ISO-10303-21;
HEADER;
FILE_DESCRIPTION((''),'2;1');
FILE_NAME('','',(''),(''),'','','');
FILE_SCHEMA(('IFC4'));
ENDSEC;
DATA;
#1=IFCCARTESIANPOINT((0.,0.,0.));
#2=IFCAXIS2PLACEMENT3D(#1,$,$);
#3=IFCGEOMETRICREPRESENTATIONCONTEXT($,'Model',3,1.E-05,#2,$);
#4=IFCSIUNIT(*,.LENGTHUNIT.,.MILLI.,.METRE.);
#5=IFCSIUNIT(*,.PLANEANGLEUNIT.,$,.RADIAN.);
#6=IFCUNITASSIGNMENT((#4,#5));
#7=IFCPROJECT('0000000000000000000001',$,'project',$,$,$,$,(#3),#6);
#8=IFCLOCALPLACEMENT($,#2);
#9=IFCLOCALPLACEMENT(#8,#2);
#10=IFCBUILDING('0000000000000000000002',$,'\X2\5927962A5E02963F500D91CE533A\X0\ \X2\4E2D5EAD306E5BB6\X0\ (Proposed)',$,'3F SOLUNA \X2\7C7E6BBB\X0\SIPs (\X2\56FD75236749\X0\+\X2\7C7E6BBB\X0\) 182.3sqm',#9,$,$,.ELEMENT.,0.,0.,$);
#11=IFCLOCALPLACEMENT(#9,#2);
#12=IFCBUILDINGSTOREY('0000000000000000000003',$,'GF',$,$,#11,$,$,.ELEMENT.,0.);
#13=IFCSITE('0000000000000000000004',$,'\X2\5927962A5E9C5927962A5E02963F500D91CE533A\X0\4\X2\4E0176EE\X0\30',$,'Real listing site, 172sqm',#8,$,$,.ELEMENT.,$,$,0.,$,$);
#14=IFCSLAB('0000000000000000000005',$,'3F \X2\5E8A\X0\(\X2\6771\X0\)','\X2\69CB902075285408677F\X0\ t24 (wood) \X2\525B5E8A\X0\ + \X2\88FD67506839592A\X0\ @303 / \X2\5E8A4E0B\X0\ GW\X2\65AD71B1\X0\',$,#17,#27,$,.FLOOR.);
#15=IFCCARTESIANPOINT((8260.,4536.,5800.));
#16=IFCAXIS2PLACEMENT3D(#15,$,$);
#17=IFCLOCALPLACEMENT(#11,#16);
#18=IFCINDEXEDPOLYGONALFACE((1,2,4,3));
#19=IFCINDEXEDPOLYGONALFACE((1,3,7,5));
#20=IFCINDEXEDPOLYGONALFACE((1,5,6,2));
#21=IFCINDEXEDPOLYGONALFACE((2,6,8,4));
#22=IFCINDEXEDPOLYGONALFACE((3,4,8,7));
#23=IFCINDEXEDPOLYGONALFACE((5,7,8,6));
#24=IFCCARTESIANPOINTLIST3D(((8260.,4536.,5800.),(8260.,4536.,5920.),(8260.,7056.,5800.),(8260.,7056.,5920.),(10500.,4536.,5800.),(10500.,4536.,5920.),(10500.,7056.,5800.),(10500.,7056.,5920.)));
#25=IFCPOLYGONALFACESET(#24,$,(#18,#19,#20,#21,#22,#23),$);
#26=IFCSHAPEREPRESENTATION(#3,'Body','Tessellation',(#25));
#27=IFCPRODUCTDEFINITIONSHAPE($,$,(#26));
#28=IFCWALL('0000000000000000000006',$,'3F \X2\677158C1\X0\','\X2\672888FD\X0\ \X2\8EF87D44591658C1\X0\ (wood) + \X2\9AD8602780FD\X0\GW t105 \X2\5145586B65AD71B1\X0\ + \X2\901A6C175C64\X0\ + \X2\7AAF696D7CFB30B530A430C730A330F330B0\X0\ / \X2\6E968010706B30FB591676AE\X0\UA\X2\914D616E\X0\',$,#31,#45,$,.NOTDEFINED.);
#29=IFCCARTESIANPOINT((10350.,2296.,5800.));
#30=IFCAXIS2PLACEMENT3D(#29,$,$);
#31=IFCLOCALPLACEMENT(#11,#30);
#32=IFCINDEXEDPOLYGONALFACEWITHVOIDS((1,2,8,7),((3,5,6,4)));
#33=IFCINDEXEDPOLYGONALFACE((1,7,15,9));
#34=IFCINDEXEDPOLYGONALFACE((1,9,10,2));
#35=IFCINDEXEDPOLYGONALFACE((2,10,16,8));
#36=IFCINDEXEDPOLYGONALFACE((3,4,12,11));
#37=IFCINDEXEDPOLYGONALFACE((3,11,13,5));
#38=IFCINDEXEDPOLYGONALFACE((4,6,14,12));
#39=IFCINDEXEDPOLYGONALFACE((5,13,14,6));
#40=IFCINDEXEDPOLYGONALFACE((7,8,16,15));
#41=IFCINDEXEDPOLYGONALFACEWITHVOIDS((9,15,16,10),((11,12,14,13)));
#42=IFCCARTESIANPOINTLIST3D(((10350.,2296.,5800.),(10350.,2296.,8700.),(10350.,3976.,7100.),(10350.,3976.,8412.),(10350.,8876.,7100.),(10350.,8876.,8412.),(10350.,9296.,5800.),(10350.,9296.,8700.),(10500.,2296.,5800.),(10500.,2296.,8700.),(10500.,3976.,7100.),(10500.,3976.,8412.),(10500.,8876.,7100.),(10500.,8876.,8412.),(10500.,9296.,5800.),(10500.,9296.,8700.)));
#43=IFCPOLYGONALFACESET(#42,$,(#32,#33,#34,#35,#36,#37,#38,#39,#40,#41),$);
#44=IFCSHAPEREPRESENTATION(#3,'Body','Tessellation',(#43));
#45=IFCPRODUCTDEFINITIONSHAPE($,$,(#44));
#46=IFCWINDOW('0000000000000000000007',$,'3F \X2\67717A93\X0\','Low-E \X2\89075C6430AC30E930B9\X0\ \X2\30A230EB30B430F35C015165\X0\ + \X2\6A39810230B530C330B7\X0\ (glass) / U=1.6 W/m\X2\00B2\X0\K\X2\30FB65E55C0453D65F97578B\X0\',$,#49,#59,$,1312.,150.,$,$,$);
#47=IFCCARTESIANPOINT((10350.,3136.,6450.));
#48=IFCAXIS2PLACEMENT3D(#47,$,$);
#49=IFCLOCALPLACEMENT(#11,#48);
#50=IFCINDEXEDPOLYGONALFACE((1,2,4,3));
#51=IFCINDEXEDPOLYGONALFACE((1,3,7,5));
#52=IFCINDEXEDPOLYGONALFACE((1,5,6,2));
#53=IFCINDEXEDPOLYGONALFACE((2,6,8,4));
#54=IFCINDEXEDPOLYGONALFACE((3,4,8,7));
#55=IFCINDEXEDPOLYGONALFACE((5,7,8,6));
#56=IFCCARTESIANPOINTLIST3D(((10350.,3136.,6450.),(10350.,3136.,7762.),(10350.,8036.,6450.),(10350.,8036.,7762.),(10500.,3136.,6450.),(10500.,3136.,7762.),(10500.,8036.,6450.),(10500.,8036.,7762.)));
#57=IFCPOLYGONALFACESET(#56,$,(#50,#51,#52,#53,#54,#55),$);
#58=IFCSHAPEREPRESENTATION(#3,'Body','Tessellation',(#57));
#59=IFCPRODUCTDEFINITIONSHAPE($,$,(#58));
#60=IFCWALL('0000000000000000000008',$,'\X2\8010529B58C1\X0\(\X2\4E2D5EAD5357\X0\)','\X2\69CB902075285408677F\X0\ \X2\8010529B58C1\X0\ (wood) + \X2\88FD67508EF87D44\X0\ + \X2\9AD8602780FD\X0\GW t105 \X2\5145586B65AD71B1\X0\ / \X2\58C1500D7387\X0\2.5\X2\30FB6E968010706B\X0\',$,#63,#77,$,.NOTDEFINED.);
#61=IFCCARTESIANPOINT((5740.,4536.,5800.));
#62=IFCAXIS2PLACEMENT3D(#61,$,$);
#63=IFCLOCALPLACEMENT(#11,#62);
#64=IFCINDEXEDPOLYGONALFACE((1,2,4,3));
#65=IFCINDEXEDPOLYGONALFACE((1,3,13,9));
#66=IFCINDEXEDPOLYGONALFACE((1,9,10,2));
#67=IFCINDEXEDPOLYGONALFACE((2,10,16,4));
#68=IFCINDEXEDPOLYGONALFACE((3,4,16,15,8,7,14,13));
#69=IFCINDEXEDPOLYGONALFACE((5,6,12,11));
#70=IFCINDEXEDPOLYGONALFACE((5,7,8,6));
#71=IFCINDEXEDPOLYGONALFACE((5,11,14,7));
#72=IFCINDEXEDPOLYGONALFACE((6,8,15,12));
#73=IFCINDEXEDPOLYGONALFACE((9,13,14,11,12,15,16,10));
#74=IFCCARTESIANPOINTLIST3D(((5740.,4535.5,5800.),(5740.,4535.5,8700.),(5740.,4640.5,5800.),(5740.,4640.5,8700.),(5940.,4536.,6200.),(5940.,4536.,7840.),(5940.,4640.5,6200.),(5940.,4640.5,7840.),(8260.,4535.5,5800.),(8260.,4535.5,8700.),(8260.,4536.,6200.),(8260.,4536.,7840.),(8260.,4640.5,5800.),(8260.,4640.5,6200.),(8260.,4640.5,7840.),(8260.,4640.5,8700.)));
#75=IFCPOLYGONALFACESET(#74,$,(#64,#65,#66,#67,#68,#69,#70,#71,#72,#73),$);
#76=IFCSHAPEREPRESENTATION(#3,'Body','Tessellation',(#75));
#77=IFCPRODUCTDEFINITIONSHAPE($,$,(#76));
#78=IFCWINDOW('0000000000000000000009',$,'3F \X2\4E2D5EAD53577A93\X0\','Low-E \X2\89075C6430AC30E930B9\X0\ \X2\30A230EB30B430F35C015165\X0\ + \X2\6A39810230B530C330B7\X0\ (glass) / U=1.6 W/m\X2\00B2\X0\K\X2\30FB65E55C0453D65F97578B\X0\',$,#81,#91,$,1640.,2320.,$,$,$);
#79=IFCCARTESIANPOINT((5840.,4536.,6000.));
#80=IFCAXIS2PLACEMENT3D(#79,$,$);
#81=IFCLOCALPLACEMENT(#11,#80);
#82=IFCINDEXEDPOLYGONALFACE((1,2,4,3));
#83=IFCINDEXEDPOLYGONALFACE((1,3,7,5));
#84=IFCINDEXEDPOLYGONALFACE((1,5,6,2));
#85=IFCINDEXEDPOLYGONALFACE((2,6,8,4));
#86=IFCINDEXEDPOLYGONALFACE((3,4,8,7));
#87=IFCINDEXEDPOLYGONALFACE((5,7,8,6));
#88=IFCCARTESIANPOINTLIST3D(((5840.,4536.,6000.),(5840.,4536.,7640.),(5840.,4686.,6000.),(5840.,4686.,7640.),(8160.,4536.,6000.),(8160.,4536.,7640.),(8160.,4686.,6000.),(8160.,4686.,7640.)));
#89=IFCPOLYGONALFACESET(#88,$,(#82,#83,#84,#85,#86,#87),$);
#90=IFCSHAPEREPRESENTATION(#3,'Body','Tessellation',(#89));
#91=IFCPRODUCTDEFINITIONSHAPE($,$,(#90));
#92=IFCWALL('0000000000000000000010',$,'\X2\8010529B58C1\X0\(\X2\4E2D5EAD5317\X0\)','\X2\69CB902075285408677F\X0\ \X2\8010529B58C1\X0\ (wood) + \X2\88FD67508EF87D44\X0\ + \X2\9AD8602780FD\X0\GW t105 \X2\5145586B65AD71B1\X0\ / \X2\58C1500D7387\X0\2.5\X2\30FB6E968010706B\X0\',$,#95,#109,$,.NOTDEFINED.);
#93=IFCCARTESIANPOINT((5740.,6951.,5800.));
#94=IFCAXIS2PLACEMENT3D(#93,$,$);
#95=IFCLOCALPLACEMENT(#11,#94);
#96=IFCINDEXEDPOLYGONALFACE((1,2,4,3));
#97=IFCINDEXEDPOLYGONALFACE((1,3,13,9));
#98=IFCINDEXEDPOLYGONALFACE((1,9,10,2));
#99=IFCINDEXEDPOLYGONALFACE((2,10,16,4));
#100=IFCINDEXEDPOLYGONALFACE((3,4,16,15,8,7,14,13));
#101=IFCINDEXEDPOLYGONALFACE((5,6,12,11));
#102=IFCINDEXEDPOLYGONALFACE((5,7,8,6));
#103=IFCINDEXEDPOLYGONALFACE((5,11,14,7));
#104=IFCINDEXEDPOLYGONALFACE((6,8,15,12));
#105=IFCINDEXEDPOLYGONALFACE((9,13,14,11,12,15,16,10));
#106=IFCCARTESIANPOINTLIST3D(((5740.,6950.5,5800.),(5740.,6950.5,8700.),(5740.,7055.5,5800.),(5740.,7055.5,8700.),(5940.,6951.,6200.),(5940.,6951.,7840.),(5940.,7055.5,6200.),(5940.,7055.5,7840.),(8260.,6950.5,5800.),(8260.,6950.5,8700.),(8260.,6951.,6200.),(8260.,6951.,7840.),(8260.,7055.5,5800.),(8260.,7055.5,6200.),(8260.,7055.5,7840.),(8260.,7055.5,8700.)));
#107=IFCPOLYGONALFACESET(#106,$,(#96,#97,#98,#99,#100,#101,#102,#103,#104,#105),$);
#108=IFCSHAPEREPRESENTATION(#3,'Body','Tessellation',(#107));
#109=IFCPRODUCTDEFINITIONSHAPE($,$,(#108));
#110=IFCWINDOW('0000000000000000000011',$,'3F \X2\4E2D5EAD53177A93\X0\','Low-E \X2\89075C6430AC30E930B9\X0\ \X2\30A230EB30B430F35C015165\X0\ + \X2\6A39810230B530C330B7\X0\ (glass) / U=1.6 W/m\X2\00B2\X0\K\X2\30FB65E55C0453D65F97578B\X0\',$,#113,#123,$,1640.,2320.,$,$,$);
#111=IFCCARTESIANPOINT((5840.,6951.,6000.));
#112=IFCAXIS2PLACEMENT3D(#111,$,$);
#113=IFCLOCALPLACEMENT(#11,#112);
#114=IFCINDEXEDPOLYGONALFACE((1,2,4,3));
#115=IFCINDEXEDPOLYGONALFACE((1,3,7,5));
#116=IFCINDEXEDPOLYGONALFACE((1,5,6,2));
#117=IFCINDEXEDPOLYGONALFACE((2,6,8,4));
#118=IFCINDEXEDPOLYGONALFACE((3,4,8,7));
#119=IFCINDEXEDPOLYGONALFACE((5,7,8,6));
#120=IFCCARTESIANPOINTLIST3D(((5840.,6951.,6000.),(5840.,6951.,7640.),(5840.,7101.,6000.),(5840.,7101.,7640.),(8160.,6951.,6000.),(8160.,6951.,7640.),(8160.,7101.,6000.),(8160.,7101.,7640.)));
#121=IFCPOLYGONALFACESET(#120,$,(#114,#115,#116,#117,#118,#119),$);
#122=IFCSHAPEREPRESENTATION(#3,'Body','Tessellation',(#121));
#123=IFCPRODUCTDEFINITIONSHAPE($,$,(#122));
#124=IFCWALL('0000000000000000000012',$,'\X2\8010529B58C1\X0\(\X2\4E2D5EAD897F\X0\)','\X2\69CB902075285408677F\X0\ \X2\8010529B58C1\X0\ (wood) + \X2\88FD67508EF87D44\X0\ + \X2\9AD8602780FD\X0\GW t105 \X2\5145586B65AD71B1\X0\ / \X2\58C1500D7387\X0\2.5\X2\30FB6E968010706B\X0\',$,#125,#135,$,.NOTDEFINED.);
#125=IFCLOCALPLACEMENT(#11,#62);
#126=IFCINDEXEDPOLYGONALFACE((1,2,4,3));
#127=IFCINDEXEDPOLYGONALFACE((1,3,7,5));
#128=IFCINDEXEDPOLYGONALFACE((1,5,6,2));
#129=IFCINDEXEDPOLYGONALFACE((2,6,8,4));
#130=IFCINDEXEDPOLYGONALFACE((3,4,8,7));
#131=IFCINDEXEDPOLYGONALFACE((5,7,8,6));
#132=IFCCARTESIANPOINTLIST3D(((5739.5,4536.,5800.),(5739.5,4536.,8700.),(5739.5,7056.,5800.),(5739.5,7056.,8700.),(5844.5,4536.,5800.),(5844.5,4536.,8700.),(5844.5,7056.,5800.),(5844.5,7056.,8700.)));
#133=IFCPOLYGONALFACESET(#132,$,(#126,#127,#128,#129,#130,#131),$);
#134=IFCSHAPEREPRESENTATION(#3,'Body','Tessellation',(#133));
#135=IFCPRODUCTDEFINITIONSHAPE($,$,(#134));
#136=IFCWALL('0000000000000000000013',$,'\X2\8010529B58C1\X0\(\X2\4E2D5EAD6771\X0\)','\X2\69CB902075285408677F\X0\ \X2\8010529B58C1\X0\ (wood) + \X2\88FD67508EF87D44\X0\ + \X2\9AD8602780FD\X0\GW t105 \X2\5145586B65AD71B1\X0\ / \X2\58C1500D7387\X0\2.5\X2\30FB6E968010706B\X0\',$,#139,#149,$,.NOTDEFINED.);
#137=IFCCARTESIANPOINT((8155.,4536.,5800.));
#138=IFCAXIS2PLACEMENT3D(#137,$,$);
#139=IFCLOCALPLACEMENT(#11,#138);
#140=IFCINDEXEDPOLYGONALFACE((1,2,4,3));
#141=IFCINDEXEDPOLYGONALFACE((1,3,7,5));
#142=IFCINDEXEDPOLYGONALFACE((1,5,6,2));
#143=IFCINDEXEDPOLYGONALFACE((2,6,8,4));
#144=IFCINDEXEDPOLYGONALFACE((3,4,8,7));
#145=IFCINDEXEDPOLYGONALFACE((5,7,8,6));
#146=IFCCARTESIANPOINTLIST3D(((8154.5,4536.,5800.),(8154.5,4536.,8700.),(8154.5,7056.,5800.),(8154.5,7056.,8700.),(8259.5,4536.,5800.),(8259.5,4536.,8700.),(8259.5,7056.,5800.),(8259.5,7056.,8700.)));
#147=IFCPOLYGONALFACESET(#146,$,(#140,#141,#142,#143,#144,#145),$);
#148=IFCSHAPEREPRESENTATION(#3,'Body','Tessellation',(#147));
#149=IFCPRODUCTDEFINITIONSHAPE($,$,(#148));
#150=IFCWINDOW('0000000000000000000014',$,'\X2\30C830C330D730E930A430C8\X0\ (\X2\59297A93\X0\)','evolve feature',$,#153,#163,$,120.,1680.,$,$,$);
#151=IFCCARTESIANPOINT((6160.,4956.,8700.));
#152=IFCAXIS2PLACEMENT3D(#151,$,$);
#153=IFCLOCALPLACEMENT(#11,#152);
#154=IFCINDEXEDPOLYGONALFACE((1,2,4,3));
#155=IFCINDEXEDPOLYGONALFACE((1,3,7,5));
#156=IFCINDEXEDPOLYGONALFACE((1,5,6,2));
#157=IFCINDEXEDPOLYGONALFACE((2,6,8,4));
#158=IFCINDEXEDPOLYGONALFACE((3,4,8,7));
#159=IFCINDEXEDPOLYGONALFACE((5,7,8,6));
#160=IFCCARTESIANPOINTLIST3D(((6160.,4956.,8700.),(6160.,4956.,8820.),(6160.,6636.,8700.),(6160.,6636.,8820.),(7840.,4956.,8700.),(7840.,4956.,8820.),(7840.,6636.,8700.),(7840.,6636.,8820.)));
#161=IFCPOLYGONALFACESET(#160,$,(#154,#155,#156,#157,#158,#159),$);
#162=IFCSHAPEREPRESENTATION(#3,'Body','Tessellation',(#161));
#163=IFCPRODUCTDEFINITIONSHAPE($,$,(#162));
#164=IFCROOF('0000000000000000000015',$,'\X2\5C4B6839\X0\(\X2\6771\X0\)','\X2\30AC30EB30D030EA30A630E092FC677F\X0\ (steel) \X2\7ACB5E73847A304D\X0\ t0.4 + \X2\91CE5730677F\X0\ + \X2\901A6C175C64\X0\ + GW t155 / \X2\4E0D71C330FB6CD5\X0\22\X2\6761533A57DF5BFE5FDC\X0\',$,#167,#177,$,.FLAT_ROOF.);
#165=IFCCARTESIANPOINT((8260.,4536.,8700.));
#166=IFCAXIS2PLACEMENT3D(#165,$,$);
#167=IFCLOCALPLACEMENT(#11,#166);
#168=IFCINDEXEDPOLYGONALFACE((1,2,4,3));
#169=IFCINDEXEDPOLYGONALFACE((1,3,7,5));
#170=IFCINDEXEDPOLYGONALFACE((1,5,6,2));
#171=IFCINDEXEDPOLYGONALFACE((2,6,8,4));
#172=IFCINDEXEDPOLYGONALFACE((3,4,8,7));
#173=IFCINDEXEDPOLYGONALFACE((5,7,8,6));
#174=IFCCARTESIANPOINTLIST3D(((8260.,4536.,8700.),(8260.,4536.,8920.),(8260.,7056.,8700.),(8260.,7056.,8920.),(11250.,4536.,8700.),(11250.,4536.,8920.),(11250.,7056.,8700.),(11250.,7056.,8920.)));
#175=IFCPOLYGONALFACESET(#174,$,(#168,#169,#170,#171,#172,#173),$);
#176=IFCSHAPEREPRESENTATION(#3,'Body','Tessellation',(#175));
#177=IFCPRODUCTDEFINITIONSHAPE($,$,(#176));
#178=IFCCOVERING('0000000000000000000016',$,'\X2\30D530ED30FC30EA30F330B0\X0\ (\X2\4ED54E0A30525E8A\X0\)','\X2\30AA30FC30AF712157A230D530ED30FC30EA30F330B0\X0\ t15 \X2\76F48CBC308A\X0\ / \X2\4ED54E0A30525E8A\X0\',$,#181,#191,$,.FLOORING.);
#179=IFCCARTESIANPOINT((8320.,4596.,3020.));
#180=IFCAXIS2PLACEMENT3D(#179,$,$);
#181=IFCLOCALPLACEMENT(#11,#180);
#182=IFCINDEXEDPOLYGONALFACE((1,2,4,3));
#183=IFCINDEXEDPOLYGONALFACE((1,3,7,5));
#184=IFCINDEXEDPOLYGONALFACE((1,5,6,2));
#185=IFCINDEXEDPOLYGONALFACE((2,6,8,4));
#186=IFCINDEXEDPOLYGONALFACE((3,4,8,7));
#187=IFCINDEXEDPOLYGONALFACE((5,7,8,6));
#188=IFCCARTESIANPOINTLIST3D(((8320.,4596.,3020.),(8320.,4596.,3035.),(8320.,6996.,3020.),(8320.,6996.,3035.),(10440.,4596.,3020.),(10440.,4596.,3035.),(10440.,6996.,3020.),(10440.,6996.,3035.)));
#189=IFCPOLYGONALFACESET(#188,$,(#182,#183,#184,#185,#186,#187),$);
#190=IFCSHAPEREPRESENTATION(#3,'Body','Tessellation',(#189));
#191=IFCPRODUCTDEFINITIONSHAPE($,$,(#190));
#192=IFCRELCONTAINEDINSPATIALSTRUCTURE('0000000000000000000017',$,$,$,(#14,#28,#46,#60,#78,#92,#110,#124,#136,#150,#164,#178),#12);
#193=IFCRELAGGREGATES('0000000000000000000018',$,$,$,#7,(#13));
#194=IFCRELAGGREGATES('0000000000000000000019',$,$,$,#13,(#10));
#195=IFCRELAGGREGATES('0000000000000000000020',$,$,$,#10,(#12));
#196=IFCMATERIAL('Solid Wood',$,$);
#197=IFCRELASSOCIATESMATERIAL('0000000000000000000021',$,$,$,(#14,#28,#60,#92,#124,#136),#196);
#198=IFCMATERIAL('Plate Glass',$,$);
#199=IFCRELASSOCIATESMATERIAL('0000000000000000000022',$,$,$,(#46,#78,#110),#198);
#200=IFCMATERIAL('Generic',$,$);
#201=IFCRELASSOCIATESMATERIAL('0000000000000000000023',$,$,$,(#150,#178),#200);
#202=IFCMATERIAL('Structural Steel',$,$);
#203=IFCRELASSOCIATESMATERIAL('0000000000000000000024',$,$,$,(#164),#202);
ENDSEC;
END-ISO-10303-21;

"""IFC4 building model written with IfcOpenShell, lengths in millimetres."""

from ifc_helpers import new_model, si_unit, frame, frame_2d, origin, place, context, project, spatial, rectangle, extrude, material, element, fill, save


model = new_model("IFC4")

# Units and contexts
model_context = context("Model", 3, precision=1e-05, world=origin())
ifc_project = project(units=[si_unit("LENGTHUNIT", "METRE", prefix="MILLI"), si_unit("PLANEANGLEUNIT", "RADIAN")], contexts=[model_context])

# Site, building, storey
site_placement = place(None, origin())
site = spatial("IfcSite", under=ifc_project, at=site_placement, Name="大阪府大阪市阿倍野区4丁目30", ObjectType="Real listing site, 172sqm", CompositionType="ELEMENT", RefElevation=0.0)
building_placement = place(site_placement, origin())
building = spatial("IfcBuilding", under=site, at=building_placement, Name="大阪市阿倍野区 中庭の家 (Proposed)", ObjectType="3F SOLUNA 籾殻SIPs (国産杉+籾殻) 182.3sqm", CompositionType="ELEMENT", ElevationOfRefHeight=0.0, ElevationOfTerrain=0.0)
storey_placement = place(building_placement, origin())
storey = spatial("IfcBuildingStorey", under=building, at=storey_placement, Name="GF", CompositionType="ELEMENT", Elevation=0.0)

# Slab
ifc_material_1 = material(Name="Solid Wood")
slab_placement = place(storey_placement, frame((8260.0, 4536.0, 5800.0)))
element("IfcSlab", 1, at=slab_placement, inside=storey, material=ifc_material_1, Name="3F 床(東)", Description="構造用合板 t24 (wood) 剛床 + 製材根太 @303 / 床下 GW断熱", PredefinedType="FLOOR", context=model_context, shape_type="SweptSolid", body=[
    extrude(rectangle(XDim=2240.0, YDim=2520.0, at=frame_2d((1120.0, 1260.0))), frame((8260.0, 4536.0, 5800.0)), (0.0, 0.0, 1.0), 120.0),
])

# Walls, openings, windows
wall_1_placement = place(storey_placement, frame((10350.0, 2296.0, 5800.0)))
wall_1 = element("IfcWall", 2, at=wall_1_placement, inside=storey, material=ifc_material_1, Name="3F 東壁", Description="木製 軸組外壁 (wood) + 高性能GW t105 充填断熱 + 通気層 + 窯業系サイディング / 準耐火・外皮UA配慮", PredefinedType="NOTDEFINED", context=model_context, shape_type="SweptSolid", body=[
    extrude(rectangle(XDim=150.0, YDim=7000.0, at=frame_2d((75.0, 3500.0))), frame((10350.0, 2296.0, 5800.0)), (0.0, 0.0, 1.0), 2900.0),
])
opening_1_placement = place(storey_placement, frame((10350.0, 3136.0, 6450.0)))
opening_1 = element("IfcOpeningElement", 3, at=opening_1_placement, cuts=wall_1, PredefinedType="NOTDEFINED", context=model_context, shape_type="SweptSolid", body=[
    extrude(rectangle(XDim=150.0, YDim=4900.0, at=frame_2d((75.0, 2450.0))), frame((10350.0, 3136.0, 6450.0)), (0.0, 0.0, 1.0), 1312.0),
])
ifc_material_2 = material(Name="Plate Glass")
window_1_placement = place(storey_placement, frame((10350.0, 3136.0, 6450.0)))
window_1 = element("IfcWindow", 4, at=window_1_placement, inside=storey, material=ifc_material_2, Name="3F 東窓", Description="Low-E 複層ガラス アルゴン封入 + 樹脂サッシ (glass) / U=1.6 W/m²K・日射取得型", OverallHeight=1312.0, OverallWidth=150.0, context=model_context, shape_type="SweptSolid", body=[
    extrude(rectangle(XDim=150.0, YDim=4900.0, at=frame_2d((75.0, 2450.0))), frame((10350.0, 3136.0, 6450.0)), (0.0, 0.0, 1.0), 1312.0),
])
fill(opening_1, window_1)
wall_2_placement = place(storey_placement, frame((5740.0, 4536.0, 5800.0)))
wall_2 = element("IfcWall", 5, at=wall_2_placement, inside=storey, material=ifc_material_1, Name="耐力壁(中庭南)", Description="構造用合板 耐力壁 (wood) + 製材軸組 + 高性能GW t105 充填断熱 / 壁倍率2.5・準耐火", PredefinedType="NOTDEFINED", context=model_context, shape_type="SweptSolid", body=[
    extrude(rectangle(XDim=2520.0, YDim=105.0, at=frame_2d((1260.0, 52.0))), frame((5740.0, 4536.0, 5800.0)), (0.0, 0.0, 1.0), 2900.0),
])
opening_2_placement = place(storey_placement, frame((5840.0, 4536.0, 6000.0)))
opening_2 = element("IfcOpeningElement", 6, at=opening_2_placement, cuts=wall_2, PredefinedType="NOTDEFINED", context=model_context, shape_type="SweptSolid", body=[
    extrude(rectangle(XDim=2320.0, YDim=150.0, at=frame_2d((1160.0, 75.0))), frame((5840.0, 4536.0, 6000.0)), (0.0, 0.0, 1.0), 1640.0),
])
window_2_placement = place(storey_placement, frame((5840.0, 4536.0, 6000.0)))
window_2 = element("IfcWindow", 7, at=window_2_placement, inside=storey, material=ifc_material_2, Name="3F 中庭南窓", Description="Low-E 複層ガラス アルゴン封入 + 樹脂サッシ (glass) / U=1.6 W/m²K・日射取得型", OverallHeight=1640.0, OverallWidth=2320.0, context=model_context, shape_type="SweptSolid", body=[
    extrude(rectangle(XDim=2320.0, YDim=150.0, at=frame_2d((1160.0, 75.0))), frame((5840.0, 4536.0, 6000.0)), (0.0, 0.0, 1.0), 1640.0),
])
fill(opening_2, window_2)
wall_3_placement = place(storey_placement, frame((5740.0, 6951.0, 5800.0)))
wall_3 = element("IfcWall", 8, at=wall_3_placement, inside=storey, material=ifc_material_1, Name="耐力壁(中庭北)", Description="構造用合板 耐力壁 (wood) + 製材軸組 + 高性能GW t105 充填断熱 / 壁倍率2.5・準耐火", PredefinedType="NOTDEFINED", context=model_context, shape_type="SweptSolid", body=[
    extrude(rectangle(XDim=2520.0, YDim=105.0, at=frame_2d((1260.0, 52.0))), frame((5740.0, 6951.0, 5800.0)), (0.0, 0.0, 1.0), 2900.0),
])
opening_3_placement = place(storey_placement, frame((5840.0, 6951.0, 6000.0)))
opening_3 = element("IfcOpeningElement", 9, at=opening_3_placement, cuts=wall_3, PredefinedType="NOTDEFINED", context=model_context, shape_type="SweptSolid", body=[
    extrude(rectangle(XDim=2320.0, YDim=150.0, at=frame_2d((1160.0, 75.0))), frame((5840.0, 6951.0, 6000.0)), (0.0, 0.0, 1.0), 1640.0),
])
window_3_placement = place(storey_placement, frame((5840.0, 6951.0, 6000.0)))
window_3 = element("IfcWindow", 10, at=window_3_placement, inside=storey, material=ifc_material_2, Name="3F 中庭北窓", Description="Low-E 複層ガラス アルゴン封入 + 樹脂サッシ (glass) / U=1.6 W/m²K・日射取得型", OverallHeight=1640.0, OverallWidth=2320.0, context=model_context, shape_type="SweptSolid", body=[
    extrude(rectangle(XDim=2320.0, YDim=150.0, at=frame_2d((1160.0, 75.0))), frame((5840.0, 6951.0, 6000.0)), (0.0, 0.0, 1.0), 1640.0),
])
fill(opening_3, window_3)

# Walls
wall_4_placement = place(storey_placement, frame((5740.0, 4536.0, 5800.0)))
element("IfcWall", 11, at=wall_4_placement, inside=storey, material=ifc_material_1, Name="耐力壁(中庭西)", Description="構造用合板 耐力壁 (wood) + 製材軸組 + 高性能GW t105 充填断熱 / 壁倍率2.5・準耐火", PredefinedType="NOTDEFINED", context=model_context, shape_type="SweptSolid", body=[
    extrude(rectangle(XDim=105.0, YDim=2520.0, at=frame_2d((52.0, 1260.0))), frame((5740.0, 4536.0, 5800.0)), (0.0, 0.0, 1.0), 2900.0),
])
wall_5_placement = place(storey_placement, frame((8155.0, 4536.0, 5800.0)))
element("IfcWall", 12, at=wall_5_placement, inside=storey, material=ifc_material_1, Name="耐力壁(中庭東)", Description="構造用合板 耐力壁 (wood) + 製材軸組 + 高性能GW t105 充填断熱 / 壁倍率2.5・準耐火", PredefinedType="NOTDEFINED", context=model_context, shape_type="SweptSolid", body=[
    extrude(rectangle(XDim=105.0, YDim=2520.0, at=frame_2d((52.0, 1260.0))), frame((8155.0, 4536.0, 5800.0)), (0.0, 0.0, 1.0), 2900.0),
])

# Window
ifc_material_3 = material(Name="Generic")
window_4_placement = place(storey_placement, frame((6160.0, 4956.0, 8700.0)))
element("IfcWindow", 13, at=window_4_placement, inside=storey, material=ifc_material_3, Name="トップライト (天窓)", Description="evolve feature", OverallHeight=120.0, OverallWidth=1680.0, context=model_context, shape_type="SweptSolid", body=[
    extrude(rectangle(XDim=1680.0, YDim=1680.0, at=frame_2d((840.0, 840.0))), frame((6160.0, 4956.0, 8700.0)), (0.0, 0.0, 1.0), 120.0),
])

# Roof
ifc_material_4 = material(Name="Structural Steel")
for number, where, name in (
    (14, (8260.0, 4536.0, 8700.0), "屋根(東)"),
):
    element("IfcRoof", number, at=place(storey_placement, frame(where)), inside=storey, material=ifc_material_4, Name=name, Description="ガルバリウム鋼板 (steel) 立平葺き t0.4 + 野地板 + 通気層 + GW t155 / 不燃・法22条区域対応", PredefinedType="FLAT_ROOF", context=model_context, shape_type="SweptSolid", body=[
        extrude(rectangle(XDim=2990.0, YDim=2520.0, at=frame_2d((1495.0, 1260.0))), frame((8260.0, 4536.0, 8700.0)), (0.0, 0.0, 1.0), 220.0),
    ])

# Covering
covering_1_placement = place(storey_placement, frame((8320.0, 4596.0, 3020.0)))
element("IfcCovering", 15, at=covering_1_placement, inside=storey, material=ifc_material_3, Name="フローリング (仕上げ床)", Description="オーク無垢フローリング t15 直貼り / 仕上げ床", PredefinedType="FLOORING", context=model_context, shape_type="SweptSolid", body=[
    extrude(rectangle(XDim=2120.0, YDim=2400.0, at=frame_2d((1060.0, 1200.0))), frame((8320.0, 4596.0, 3020.0)), (0.0, 0.0, 1.0), 15.0),
])

save(model, "model.ifc")
